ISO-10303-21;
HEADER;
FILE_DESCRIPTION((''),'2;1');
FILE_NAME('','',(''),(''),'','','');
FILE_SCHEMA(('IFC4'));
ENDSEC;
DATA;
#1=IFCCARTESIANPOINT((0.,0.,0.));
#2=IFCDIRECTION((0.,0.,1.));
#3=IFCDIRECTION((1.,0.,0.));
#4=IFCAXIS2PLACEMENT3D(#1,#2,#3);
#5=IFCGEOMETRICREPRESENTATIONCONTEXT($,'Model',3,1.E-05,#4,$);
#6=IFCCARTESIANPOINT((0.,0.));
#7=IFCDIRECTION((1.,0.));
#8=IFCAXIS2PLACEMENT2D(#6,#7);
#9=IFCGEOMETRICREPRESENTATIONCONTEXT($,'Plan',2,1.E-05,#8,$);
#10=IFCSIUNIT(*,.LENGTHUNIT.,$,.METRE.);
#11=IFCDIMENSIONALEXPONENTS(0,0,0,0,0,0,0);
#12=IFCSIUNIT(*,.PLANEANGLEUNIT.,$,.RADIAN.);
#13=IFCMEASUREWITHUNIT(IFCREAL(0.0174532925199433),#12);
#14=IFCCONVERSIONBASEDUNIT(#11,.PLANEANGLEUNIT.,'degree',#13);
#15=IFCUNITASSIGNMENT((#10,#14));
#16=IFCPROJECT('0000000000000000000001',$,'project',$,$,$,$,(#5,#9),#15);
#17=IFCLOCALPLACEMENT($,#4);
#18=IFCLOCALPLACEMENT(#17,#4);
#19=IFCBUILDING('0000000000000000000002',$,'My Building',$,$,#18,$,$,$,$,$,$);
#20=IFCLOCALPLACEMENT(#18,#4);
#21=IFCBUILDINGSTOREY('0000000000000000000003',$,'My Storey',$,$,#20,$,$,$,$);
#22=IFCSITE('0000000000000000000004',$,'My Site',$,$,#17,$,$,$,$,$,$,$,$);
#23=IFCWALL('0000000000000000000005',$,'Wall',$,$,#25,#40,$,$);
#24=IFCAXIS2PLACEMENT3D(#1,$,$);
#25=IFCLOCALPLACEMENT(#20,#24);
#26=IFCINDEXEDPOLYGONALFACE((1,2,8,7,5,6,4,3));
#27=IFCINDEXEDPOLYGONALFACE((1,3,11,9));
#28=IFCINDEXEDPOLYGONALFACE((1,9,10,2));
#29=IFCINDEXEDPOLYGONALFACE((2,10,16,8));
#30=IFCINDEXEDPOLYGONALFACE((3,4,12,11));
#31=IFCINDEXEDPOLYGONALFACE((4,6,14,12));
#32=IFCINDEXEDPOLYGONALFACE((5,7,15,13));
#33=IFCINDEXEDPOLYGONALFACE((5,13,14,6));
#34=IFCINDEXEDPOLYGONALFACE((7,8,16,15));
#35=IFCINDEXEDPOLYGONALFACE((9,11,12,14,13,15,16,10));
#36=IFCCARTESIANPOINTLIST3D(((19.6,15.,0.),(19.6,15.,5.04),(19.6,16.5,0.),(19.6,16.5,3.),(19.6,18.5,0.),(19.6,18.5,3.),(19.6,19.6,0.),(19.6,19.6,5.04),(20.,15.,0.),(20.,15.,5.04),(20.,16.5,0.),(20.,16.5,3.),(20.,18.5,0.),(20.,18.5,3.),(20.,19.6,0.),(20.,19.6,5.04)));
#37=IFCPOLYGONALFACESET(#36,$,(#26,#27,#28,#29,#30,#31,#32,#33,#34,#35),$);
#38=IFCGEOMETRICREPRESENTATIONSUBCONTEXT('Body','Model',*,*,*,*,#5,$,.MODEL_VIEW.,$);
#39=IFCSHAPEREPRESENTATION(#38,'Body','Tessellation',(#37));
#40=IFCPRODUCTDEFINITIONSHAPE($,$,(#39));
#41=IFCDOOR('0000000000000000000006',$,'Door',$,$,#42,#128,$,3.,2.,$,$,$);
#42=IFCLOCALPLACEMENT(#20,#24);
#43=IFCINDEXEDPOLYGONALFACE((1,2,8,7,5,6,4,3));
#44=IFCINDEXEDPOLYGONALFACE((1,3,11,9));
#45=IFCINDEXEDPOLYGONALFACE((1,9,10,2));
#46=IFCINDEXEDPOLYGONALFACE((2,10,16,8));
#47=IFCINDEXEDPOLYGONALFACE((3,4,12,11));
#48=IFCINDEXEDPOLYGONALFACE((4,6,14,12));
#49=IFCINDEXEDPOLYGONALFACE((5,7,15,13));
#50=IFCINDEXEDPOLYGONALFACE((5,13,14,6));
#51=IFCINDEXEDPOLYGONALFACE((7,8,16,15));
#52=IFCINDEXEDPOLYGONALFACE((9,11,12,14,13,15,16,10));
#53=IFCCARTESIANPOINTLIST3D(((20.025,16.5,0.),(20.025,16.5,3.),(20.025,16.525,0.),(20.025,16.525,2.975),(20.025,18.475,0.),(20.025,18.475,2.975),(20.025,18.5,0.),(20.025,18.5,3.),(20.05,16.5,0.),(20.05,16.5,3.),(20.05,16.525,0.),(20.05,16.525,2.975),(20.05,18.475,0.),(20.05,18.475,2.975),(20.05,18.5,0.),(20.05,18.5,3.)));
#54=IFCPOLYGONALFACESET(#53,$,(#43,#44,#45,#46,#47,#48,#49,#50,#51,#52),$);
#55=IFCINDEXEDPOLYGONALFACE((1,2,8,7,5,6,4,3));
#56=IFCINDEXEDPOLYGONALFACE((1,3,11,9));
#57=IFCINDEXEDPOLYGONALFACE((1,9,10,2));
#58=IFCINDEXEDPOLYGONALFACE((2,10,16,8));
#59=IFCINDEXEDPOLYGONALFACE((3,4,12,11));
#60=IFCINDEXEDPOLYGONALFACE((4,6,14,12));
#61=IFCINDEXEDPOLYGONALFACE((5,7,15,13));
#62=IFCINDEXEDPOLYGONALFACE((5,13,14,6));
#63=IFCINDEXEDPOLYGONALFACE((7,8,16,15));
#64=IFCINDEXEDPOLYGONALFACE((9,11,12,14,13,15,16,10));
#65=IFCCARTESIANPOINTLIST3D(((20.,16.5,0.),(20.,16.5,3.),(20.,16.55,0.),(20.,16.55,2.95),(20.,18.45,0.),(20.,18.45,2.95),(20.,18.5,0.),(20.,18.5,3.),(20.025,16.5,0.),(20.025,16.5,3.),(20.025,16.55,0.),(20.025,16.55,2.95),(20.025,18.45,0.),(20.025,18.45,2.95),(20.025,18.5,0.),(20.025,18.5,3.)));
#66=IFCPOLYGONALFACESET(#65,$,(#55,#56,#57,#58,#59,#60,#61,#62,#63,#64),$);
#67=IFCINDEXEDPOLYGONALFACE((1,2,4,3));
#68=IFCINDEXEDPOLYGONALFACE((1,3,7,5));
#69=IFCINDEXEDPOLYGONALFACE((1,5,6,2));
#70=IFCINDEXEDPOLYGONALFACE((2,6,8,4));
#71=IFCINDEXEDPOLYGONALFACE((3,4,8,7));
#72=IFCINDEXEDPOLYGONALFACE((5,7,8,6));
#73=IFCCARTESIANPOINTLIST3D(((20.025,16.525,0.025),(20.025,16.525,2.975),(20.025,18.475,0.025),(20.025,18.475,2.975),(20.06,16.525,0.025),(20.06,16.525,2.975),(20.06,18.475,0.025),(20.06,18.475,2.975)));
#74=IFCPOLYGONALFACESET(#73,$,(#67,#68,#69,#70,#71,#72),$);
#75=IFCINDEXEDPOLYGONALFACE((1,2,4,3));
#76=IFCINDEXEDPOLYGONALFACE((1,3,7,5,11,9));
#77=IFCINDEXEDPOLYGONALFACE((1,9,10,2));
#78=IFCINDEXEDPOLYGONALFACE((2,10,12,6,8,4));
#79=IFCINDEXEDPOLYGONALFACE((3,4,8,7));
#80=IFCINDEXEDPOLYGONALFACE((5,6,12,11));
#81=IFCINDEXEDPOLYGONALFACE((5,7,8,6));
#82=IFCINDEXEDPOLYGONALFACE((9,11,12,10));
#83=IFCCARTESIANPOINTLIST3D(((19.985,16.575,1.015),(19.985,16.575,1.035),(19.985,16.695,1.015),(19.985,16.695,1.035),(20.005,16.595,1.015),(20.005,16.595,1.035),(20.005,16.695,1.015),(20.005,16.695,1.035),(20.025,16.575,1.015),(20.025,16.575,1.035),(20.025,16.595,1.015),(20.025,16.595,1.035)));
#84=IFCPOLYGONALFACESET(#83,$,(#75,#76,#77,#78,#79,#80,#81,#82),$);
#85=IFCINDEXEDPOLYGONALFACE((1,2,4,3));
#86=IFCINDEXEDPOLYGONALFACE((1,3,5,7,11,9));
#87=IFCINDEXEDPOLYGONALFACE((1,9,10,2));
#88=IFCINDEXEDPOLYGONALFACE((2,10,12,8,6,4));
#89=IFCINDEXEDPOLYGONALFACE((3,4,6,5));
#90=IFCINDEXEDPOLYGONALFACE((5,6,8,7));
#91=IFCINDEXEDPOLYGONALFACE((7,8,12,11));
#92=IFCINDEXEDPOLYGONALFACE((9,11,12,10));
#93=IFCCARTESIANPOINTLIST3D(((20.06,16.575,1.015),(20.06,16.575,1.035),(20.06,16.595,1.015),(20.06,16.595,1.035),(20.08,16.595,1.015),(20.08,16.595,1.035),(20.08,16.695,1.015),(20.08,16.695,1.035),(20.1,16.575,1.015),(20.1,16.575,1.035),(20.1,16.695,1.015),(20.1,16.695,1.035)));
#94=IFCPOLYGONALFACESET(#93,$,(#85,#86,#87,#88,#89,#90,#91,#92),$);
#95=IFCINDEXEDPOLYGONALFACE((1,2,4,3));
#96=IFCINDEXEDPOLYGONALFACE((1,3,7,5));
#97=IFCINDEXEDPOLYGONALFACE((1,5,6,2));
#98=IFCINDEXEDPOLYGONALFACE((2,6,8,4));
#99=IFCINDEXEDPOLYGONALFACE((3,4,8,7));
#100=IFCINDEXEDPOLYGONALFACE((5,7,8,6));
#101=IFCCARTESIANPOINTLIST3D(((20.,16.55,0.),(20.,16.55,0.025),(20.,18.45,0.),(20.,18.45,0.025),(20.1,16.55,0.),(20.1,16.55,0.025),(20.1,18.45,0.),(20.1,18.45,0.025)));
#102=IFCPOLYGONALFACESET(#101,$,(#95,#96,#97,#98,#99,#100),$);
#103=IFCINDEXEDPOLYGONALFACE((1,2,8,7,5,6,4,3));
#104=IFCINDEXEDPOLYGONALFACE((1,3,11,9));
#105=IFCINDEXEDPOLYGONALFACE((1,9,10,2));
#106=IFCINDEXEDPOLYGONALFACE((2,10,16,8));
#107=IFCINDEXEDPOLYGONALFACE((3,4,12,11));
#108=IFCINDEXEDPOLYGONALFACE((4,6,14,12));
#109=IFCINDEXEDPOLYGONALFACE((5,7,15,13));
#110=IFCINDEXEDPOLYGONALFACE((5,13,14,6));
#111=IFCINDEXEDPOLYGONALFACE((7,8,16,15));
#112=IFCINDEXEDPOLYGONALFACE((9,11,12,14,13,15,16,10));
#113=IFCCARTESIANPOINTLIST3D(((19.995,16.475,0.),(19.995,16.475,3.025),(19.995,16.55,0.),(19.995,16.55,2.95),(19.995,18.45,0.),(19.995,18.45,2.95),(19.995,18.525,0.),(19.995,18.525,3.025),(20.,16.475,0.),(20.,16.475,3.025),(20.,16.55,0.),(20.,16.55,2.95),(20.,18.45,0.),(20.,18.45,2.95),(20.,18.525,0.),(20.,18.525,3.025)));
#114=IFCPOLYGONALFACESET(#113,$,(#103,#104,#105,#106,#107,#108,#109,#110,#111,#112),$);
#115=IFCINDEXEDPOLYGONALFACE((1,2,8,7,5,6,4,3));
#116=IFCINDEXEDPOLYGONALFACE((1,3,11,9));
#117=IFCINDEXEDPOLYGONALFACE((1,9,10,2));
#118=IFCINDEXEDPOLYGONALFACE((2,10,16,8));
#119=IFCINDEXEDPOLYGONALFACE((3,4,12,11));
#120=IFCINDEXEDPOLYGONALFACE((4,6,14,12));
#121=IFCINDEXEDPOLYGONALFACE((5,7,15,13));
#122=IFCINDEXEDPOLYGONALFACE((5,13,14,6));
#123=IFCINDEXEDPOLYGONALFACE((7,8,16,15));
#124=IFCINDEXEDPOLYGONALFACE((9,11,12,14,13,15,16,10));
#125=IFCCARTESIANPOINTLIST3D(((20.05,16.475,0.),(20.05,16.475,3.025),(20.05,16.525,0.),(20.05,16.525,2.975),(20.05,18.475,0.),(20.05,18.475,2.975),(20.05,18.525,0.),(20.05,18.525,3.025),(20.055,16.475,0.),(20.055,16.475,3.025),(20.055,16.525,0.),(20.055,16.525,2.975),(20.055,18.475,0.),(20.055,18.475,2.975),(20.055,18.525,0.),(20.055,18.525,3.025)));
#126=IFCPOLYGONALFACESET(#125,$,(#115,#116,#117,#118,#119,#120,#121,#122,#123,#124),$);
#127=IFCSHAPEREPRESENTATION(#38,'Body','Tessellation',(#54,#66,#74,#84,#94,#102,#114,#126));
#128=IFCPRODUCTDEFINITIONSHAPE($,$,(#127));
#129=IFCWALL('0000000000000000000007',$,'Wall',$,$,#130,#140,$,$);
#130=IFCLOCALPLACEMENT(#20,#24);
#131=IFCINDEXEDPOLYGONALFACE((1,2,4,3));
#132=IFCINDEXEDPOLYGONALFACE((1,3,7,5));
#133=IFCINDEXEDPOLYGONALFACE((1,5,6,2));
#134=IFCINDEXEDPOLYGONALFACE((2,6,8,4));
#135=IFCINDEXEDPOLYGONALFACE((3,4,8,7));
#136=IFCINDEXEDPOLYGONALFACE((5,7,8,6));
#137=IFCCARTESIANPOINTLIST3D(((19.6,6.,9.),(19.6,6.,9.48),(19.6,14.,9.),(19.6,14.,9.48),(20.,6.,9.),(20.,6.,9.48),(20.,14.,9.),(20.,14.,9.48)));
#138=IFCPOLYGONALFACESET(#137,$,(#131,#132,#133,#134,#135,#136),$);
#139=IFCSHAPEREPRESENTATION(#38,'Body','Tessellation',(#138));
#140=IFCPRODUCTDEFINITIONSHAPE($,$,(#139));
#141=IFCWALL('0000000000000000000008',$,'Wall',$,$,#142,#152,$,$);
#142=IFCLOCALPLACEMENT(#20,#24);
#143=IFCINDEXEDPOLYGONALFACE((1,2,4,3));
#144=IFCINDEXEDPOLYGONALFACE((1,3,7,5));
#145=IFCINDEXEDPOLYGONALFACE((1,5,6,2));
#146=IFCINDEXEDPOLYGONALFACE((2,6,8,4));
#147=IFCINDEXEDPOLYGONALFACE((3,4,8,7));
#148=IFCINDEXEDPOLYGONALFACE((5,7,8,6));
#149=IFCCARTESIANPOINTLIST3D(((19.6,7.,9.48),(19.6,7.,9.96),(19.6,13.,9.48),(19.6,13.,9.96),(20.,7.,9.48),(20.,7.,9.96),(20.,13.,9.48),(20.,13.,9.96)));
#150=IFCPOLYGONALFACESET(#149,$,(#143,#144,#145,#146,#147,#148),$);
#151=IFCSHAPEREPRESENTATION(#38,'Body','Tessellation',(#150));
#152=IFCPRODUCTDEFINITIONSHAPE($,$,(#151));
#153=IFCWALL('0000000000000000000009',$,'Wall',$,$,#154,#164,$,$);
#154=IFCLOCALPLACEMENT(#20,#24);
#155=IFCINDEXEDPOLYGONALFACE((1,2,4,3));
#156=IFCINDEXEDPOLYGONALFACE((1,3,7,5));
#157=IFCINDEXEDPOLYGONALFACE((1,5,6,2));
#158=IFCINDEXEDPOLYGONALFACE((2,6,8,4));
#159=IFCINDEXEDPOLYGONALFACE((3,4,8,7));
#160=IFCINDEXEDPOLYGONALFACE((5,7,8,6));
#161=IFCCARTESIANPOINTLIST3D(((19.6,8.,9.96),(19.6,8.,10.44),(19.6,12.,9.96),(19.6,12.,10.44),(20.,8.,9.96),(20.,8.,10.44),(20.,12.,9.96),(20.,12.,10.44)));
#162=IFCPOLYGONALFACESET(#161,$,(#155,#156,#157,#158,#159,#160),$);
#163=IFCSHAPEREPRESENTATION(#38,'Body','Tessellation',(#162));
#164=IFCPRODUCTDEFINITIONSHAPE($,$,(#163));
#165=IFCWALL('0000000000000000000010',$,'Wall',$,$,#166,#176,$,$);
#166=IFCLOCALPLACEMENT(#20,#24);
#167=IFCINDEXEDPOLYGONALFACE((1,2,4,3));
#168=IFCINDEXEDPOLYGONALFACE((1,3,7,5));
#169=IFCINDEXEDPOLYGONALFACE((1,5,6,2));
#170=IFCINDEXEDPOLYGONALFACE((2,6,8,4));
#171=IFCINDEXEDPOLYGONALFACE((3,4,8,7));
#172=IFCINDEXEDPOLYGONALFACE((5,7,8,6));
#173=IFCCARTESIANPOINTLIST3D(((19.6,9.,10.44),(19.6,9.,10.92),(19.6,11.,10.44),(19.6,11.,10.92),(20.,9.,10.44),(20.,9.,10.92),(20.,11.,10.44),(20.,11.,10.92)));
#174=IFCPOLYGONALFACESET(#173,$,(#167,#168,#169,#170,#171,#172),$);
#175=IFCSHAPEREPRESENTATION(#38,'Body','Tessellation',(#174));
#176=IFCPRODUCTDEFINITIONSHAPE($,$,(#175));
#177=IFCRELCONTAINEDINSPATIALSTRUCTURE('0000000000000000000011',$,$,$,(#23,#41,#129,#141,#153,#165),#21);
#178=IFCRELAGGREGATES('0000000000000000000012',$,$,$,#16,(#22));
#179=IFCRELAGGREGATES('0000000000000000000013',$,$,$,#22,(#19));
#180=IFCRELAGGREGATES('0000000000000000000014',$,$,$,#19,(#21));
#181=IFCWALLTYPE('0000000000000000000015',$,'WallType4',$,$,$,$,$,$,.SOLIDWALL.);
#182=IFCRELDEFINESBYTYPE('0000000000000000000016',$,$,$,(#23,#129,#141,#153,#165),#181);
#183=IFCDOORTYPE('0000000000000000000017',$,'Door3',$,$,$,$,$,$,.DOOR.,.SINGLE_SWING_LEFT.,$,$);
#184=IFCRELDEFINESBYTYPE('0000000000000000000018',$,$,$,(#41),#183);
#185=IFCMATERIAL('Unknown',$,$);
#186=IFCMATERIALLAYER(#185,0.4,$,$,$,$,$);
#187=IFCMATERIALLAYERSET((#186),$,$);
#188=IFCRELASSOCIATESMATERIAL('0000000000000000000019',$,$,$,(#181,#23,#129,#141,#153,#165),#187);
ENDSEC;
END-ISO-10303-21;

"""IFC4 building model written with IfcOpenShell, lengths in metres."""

from ifc_helpers import new_model, entity, si_unit, converted_unit, frame, origin_with_axes, origin_2d_with_axis, place, context, subcontext, project, spatial, line, indexed_curve, outline, extrude, shape, source, transform, mapped, material, layer, layer_set, layer_usage, type_object, type_shapes, element, fill, save


model = new_model("IFC4")

# Units and contexts
model_context = context("Model", 3, precision=1e-05, world=origin_with_axes())
plan_context = context("Plan", 2, precision=1e-05, world=origin_2d_with_axis())
body_context_1 = subcontext(model_context, "Body", "Model", "MODEL_VIEW")
body_context_2 = subcontext(plan_context, "Body", "Plan", "PLAN_VIEW")
ifc_project = project(units=[si_unit("LENGTHUNIT", "METRE"), converted_unit("PLANEANGLEUNIT", "degree", entity("IfcReal", 0.0174532925199433), si_unit("PLANEANGLEUNIT", "RADIAN"), dimensions=[0, 0, 0, 0, 0, 0, 0])], contexts=[model_context, plan_context])

# Site, building, storey
site_placement = place(None, origin_with_axes())
site = spatial("IfcSite", under=ifc_project, at=site_placement, Name="My Site")
building_placement = place(site_placement, origin_with_axes())
building = spatial("IfcBuilding", under=site, at=building_placement, Name="My Building")
storey_placement = place(building_placement, origin_with_axes())
storey = spatial("IfcBuildingStorey", under=building, at=storey_placement, Name="My Storey")

# Shared definitions
ifc_material = material(Name="Unknown")

# Wall, opening, door
ifc_layer_1 = layer(ifc_material, 0.4)
ifc_layer_set_1 = layer_set([ifc_layer_1])
wall_type_1 = type_object("IfcWallType", Name="WallType4", PredefinedType="SOLIDWALL", material=ifc_layer_set_1)
shared_shape_1 = source(origin_with_axes(), body_context_1, "Body", "SweptSolid", [
    extrude(outline(indexed_curve([(0.0, 0.0), (2.0, 0.0), (2.0, 3.0), (0.0, 3.0)], segments=[line(1, 2, 3, 4, 1)])), frame((0.0, -0.6, 0.0), z_axis=(0.0, -1.0, 0.0), x_axis=(1.0, 0.0, 0.0)), (0.0, 0.0, -1.0), 1.2),
])
door_type_1 = type_object("IfcDoorType", Name="Door3", OperationType="SINGLE_SWING_LEFT", PredefinedType="DOOR")
shared_shape_2 = source(origin_with_axes(), body_context_1, "Body", "SweptSolid", [
    extrude(outline(indexed_curve([(0.0, 0.0), (0.0, 3.0), (2.0, 3.0), (2.0, 0.0), (1.975, 0.0), (1.975, 2.975), (0.025, 2.975), (0.025, 0.0)], segments=[line(1, 2, 3, 4, 5, 6, 7, 8, 1)])), frame((0.0, 0.025, 0.0), z_axis=(0.0, -1.0, 0.0), x_axis=(1.0, 0.0, 0.0)), (0.0, 0.0, -1.0), 0.025),
    extrude(outline(indexed_curve([(0.0, 0.0), (0.0, 3.0), (2.0, 3.0), (2.0, 0.0), (1.95, 0.0), (1.95, 2.95), (0.05, 2.95), (0.05, 0.0)], segments=[line(1, 2, 3, 4, 5, 6, 7, 8, 1)])), frame((0.0, 0.0, 0.0), z_axis=(0.0, -1.0, 0.0), x_axis=(1.0, 0.0, 0.0)), (0.0, 0.0, -1.0), 0.025),
    extrude(outline(indexed_curve([(0.0, 0.0), (1.95, 0.0), (1.95, 0.035), (0.0, 0.035)], segments=[line(1, 2, 3, 4, 1)])), frame((0.025, 0.025, 0.025), z_axis=(0.0, 0.0, 1.0), x_axis=(1.0, 0.0, 0.0)), (0.0, 0.0, 1.0), 2.95),
    extrude(outline(indexed_curve([(0.0, 0.0), (0.0, -0.04), (-0.12, -0.04), (-0.12, -0.02), (-0.02, -0.02), (-0.02, 0.0)], segments=[line(1, 2, 3, 4, 5, 6, 1)])), frame((1.925, 0.025, 1.015), z_axis=(0.0, 0.0, 1.0), x_axis=(1.0, 0.0, 0.0)), (0.0, 0.0, 1.0), 0.02),
    extrude(outline(indexed_curve([(0.0, 0.0), (0.0, 0.04), (-0.12, 0.04), (-0.12, 0.02), (-0.02, 0.02), (-0.02, 0.0)], segments=[line(1, 2, 3, 4, 5, 6, 1)])), frame((1.925, 0.06, 1.015), z_axis=(0.0, 0.0, 1.0), x_axis=(1.0, 0.0, 0.0)), (0.0, 0.0, 1.0), 0.02),
    extrude(outline(indexed_curve([(0.0, 0.0), (1.9, 0.0), (1.9, 0.1), (0.0, 0.1)], segments=[line(1, 2, 3, 4, 1)])), frame((0.05, 0.0, 0.0), z_axis=(0.0, 0.0, 1.0), x_axis=(1.0, 0.0, 0.0)), (0.0, 0.0, 1.0), 0.025),
    extrude(outline(indexed_curve([(0.0, 0.0), (0.0, 3.025), (2.05, 3.025), (2.05, 0.0), (1.975, 0.0), (1.975, 2.95), (0.075, 2.95), (0.075, 0.0)], segments=[line(1, 2, 3, 4, 5, 6, 7, 8, 1)])), frame((-0.025, -0.005, 0.0), z_axis=(0.0, -1.0, 0.0), x_axis=(1.0, 0.0, 0.0)), (0.0, 0.0, -1.0), 0.005),
    extrude(outline(indexed_curve([(0.0, 0.0), (0.0, 3.025), (2.05, 3.025), (2.05, 0.0), (2.0, 0.0), (2.0, 2.975), (0.05, 2.975), (0.05, 0.0)], segments=[line(1, 2, 3, 4, 5, 6, 7, 8, 1)])), frame((-0.025, 0.05, 0.0), z_axis=(0.0, -1.0, 0.0), x_axis=(1.0, 0.0, 0.0)), (0.0, 0.0, -1.0), 0.005),
])
shared_shape_3 = source(origin_with_axes(), body_context_2, "Body", "Curve2D", [
    entity("IfcIndexedPolyCurve", entity("IfcCartesianPointList2D", [[0.0, 0.0], [0.0, 0.05], [0.025, 0.05], [0.025, 0.025], [0.05, 0.025], [0.05, 0.0]]), [entity("IfcLineIndex", [1, 2, 3, 4, 5, 6, 1])]),
    entity("IfcIndexedPolyCurve", entity("IfcCartesianPointList2D", [[2.0, 0.0], [2.0, 0.05], [1.975, 0.05], [1.975, 0.025], [1.95, 0.025], [1.95, 0.0]]), [entity("IfcLineIndex", [1, 2, 3, 4, 5, 6, 1])]),
    entity("IfcTrimmedCurve", entity("IfcEllipse", entity("IfcAxis2Placement2D", entity("IfcCartesianPoint", [0.06, 0.05]), entity("IfcDirection", [1.0, 0.0])), 1.915, 1.95), [entity("IfcCartesianPoint", [1.975, 0.05])], [entity("IfcCartesianPoint", [0.06, 2.0])], True, "CARTESIAN"),
    entity("IfcIndexedPolyCurve", entity("IfcCartesianPointList2D", [[0.025, 0.05], [0.06, 0.05], [0.06, 2.0], [0.025, 2.0]]), [entity("IfcLineIndex", [1, 2, 3, 4, 1])]),
])
type_shapes(door_type_1, [shared_shape_2, shared_shape_3])
ifc_layer_usage_1 = layer_usage(ifc_layer_set_1, "AXIS2", "POSITIVE", 0.0)
wall_1_placement = place(storey_placement, frame((19.6, 19.6, 0.0), z_axis=(0.0, 0.0, 1.0), x_axis=(0.0, -1.0, 0.0)))
wall_1 = element("IfcWall", 1, at=wall_1_placement, inside=storey, type_object=wall_type_1, material=ifc_layer_usage_1, Name="Wall", context=body_context_1, shape_type="SweptSolid", body=[
    extrude(outline(indexed_curve([(0.0, 0.0), (0.0, 0.4), (4.6, 0.4), (4.6, 0.0), (0.0, 0.0)], self_intersect=False)), origin_with_axes(), (0.0, 0.0, 1.0), 5.04),
])
opening_1_placement = place(wall_1_placement, frame((1.1, 0.0, 0.0), z_axis=(0.0, 0.0, 1.0), x_axis=(1.0, 0.0, 0.0)))
opening_1 = element("IfcOpeningElement", 2, at=opening_1_placement, cuts=wall_1, PredefinedType="OPENING", context=body_context_1, shape_type="MappedRepresentation", body=[
    mapped(shared_shape_1, transform((0.0, 0.0, 0.0), x_axis=(1.0, 0.0, 0.0), y_axis=(0.0, 1.0, 0.0), z_axis=(0.0, 0.0, 1.0), scale=1.0)),
])
door_1_placement = place(opening_1_placement, frame((0.0, 0.4, 0.0), z_axis=(0.0, 0.0, 1.0), x_axis=(1.0, 0.0, 0.0)))
door_1 = element("IfcDoor", 3, at=door_1_placement, inside=storey, type_object=door_type_1, Name="Door", OverallHeight=3.0, OverallWidth=2.0, shapes=[
    shape(body_context_1, "Body", "MappedRepresentation", [mapped(shared_shape_2, transform((0.0, 0.0, 0.0), x_axis=(1.0, 0.0, 0.0), y_axis=(0.0, 1.0, 0.0), z_axis=(0.0, 0.0, 1.0), scale=1.0))]),
    shape(body_context_2, "Body", "MappedRepresentation", [mapped(shared_shape_3, transform((0.0, 0.0, 0.0), x_axis=(1.0, 0.0, 0.0), y_axis=(0.0, 1.0, 0.0), z_axis=(0.0, 0.0, 1.0), scale=1.0))]),
])
fill(opening_1, door_1)

# Walls
ifc_layer_usage_2 = layer_usage(ifc_layer_set_1, "AXIS2", "POSITIVE", 0.0)
wall_2_placement = place(storey_placement, frame((20.0, 6.0, 9.0), z_axis=(0.0, 0.0, 1.0), x_axis=(0.0, 1.0, 0.0)))
element("IfcWall", 4, at=wall_2_placement, inside=storey, type_object=wall_type_1, material=ifc_layer_usage_2, Name="Wall", context=body_context_1, shape_type="SweptSolid", body=[
    extrude(outline(indexed_curve([(0.0, 0.0), (0.0, 0.4), (8.0, 0.4), (8.0, 0.0), (0.0, 0.0)], self_intersect=False)), origin_with_axes(), (0.0, 0.0, 1.0), 0.48),
])
ifc_layer_usage_3 = layer_usage(ifc_layer_set_1, "AXIS2", "POSITIVE", 0.0)
wall_3_placement = place(storey_placement, frame((20.0, 7.0, 9.48), z_axis=(0.0, 0.0, 1.0), x_axis=(0.0, 1.0, 0.0)))
element("IfcWall", 5, at=wall_3_placement, inside=storey, type_object=wall_type_1, material=ifc_layer_usage_3, Name="Wall", context=body_context_1, shape_type="SweptSolid", body=[
    extrude(outline(indexed_curve([(0.0, 0.0), (0.0, 0.4), (6.0, 0.4), (6.0, 0.0), (0.0, 0.0)], self_intersect=False)), origin_with_axes(), (0.0, 0.0, 1.0), 0.48),
])
ifc_layer_usage_4 = layer_usage(ifc_layer_set_1, "AXIS2", "POSITIVE", 0.0)
wall_4_placement = place(storey_placement, frame((20.0, 8.0, 9.96), z_axis=(0.0, 0.0, 1.0), x_axis=(0.0, 1.0, 0.0)))
element("IfcWall", 6, at=wall_4_placement, inside=storey, type_object=wall_type_1, material=ifc_layer_usage_4, Name="Wall", context=body_context_1, shape_type="SweptSolid", body=[
    extrude(outline(indexed_curve([(0.0, 0.0), (0.0, 0.4), (4.0, 0.4), (4.0, 0.0), (0.0, 0.0)], self_intersect=False)), origin_with_axes(), (0.0, 0.0, 1.0), 0.48),
])
ifc_layer_usage_5 = layer_usage(ifc_layer_set_1, "AXIS2", "POSITIVE", 0.0)
wall_5_placement = place(storey_placement, frame((20.0, 9.0, 10.44), z_axis=(0.0, 0.0, 1.0), x_axis=(0.0, 1.0, 0.0)))
element("IfcWall", 7, at=wall_5_placement, inside=storey, type_object=wall_type_1, material=ifc_layer_usage_5, Name="Wall", context=body_context_1, shape_type="SweptSolid", body=[
    extrude(outline(indexed_curve([(0.0, 0.0), (0.0, 0.4), (2.0, 0.4), (2.0, 0.0), (0.0, 0.0)], self_intersect=False)), origin_with_axes(), (0.0, 0.0, 1.0), 0.48),
])

save(model, "model.ifc")
